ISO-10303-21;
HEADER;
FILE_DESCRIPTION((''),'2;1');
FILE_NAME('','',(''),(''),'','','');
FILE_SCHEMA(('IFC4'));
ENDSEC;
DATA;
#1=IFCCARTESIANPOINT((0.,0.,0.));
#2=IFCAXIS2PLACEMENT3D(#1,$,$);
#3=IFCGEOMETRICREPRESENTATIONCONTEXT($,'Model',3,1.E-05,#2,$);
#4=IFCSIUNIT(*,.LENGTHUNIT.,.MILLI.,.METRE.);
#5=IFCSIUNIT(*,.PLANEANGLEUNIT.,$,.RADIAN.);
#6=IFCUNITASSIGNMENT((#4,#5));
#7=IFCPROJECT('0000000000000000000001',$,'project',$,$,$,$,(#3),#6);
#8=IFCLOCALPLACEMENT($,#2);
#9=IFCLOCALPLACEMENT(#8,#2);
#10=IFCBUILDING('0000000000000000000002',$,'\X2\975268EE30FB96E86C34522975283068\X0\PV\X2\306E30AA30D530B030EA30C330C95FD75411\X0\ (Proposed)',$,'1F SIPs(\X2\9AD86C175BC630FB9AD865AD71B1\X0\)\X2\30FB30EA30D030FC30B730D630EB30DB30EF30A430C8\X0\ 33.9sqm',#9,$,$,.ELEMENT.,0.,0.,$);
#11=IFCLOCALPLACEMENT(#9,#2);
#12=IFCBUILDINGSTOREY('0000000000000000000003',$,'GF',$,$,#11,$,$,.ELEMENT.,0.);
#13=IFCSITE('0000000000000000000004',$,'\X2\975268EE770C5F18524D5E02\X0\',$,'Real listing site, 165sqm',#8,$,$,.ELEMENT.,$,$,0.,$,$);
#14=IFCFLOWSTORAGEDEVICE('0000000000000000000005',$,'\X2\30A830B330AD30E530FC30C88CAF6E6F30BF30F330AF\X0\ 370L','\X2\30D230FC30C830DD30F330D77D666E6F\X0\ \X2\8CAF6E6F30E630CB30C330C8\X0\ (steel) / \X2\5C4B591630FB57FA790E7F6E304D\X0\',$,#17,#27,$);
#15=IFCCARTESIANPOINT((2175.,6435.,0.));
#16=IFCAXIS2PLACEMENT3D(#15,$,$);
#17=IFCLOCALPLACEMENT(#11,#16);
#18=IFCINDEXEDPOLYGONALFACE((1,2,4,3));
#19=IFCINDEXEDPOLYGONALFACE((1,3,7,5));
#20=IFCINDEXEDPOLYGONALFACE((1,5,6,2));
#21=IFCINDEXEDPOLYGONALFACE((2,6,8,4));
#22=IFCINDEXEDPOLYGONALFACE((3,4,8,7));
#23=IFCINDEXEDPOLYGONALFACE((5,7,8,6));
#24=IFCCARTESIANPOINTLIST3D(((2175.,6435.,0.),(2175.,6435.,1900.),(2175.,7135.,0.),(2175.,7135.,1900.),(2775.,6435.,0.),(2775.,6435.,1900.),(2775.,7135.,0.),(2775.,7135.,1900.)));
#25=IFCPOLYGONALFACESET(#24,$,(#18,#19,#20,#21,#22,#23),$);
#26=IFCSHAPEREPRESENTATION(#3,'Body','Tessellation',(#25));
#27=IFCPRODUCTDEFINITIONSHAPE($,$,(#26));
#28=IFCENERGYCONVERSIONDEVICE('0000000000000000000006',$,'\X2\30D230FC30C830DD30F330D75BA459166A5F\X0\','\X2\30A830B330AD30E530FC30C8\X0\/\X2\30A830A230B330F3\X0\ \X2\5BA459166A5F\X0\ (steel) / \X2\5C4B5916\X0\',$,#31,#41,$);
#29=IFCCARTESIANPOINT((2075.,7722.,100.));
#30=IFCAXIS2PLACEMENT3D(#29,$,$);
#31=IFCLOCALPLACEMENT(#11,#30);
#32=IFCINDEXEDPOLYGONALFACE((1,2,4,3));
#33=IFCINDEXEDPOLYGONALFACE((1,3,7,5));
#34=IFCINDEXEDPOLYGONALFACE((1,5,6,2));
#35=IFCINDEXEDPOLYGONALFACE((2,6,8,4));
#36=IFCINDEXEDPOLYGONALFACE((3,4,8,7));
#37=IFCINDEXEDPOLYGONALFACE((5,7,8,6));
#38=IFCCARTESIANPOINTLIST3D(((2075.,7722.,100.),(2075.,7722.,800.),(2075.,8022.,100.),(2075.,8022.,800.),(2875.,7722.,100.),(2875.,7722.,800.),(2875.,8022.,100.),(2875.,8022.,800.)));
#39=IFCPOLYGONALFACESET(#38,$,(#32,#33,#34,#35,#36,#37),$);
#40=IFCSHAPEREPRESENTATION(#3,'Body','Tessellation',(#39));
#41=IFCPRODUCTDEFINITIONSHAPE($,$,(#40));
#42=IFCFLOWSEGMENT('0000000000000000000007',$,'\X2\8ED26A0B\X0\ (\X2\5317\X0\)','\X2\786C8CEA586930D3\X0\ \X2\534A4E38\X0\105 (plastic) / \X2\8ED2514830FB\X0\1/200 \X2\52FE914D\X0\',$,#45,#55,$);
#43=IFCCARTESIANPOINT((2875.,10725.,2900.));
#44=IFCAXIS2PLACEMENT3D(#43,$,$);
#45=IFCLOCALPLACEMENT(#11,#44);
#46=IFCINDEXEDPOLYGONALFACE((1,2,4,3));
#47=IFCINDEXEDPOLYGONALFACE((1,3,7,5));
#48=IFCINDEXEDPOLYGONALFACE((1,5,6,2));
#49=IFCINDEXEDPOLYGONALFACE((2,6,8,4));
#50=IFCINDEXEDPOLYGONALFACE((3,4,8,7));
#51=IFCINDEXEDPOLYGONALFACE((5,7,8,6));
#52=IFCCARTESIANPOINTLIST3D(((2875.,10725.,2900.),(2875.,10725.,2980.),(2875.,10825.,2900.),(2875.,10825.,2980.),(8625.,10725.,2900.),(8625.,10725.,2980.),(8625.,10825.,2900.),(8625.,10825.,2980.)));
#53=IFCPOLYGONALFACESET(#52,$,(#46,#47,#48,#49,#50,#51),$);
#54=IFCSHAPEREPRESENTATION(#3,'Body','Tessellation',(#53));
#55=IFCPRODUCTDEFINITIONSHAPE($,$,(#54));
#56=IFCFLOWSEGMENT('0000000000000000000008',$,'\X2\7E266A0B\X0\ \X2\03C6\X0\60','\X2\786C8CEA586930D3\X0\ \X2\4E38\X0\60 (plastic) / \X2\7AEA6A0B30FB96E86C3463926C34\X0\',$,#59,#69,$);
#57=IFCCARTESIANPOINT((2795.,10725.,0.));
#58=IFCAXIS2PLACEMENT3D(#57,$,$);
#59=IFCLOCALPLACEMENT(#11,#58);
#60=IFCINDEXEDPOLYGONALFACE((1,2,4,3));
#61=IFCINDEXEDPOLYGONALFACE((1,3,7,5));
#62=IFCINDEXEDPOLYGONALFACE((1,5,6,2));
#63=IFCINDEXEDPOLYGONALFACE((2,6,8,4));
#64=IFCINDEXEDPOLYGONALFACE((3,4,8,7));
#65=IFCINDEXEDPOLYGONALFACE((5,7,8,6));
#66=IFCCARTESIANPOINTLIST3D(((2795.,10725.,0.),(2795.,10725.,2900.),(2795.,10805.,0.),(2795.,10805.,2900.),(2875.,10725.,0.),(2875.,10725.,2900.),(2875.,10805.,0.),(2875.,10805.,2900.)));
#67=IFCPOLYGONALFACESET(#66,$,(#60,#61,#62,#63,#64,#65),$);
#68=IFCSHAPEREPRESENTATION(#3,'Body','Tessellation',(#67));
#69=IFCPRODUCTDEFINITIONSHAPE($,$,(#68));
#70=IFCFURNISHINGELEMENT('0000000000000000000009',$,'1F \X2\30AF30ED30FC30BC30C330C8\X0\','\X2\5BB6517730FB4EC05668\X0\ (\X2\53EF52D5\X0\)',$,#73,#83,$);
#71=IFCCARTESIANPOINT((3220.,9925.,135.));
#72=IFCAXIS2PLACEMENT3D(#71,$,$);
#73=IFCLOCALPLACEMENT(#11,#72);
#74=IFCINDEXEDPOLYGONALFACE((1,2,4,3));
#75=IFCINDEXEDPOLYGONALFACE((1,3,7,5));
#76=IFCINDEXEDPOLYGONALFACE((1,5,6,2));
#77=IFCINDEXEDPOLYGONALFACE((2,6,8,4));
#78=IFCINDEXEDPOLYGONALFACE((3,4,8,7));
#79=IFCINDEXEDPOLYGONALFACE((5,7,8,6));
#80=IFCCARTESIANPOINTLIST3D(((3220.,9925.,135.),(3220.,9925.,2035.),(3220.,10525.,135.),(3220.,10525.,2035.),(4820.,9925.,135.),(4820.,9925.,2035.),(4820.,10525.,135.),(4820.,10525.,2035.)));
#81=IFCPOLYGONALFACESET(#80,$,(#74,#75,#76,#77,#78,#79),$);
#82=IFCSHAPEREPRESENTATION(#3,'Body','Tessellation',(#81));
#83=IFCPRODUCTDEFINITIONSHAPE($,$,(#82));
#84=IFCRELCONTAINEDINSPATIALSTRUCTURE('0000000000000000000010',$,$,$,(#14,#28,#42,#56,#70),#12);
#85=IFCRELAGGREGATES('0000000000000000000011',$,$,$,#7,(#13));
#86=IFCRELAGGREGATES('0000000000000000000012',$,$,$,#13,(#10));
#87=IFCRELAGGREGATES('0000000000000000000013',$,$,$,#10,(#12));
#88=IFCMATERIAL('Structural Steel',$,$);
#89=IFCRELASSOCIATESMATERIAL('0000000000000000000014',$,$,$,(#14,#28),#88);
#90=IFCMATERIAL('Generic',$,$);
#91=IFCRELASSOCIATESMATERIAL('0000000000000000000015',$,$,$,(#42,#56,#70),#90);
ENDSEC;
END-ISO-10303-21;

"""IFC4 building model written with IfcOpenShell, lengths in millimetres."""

from ifc_helpers import new_model, si_unit, frame, frame_2d, origin, place, context, project, spatial, rectangle, extrude, material, element, save


model = new_model("IFC4")

# Units and contexts
model_context = context("Model", 3, precision=1e-05, world=origin())
ifc_project = project(units=[si_unit("LENGTHUNIT", "METRE", prefix="MILLI"), si_unit("PLANEANGLEUNIT", "RADIAN")], contexts=[model_context])

# Site, building, storey
site_placement = place(None, origin())
site = spatial("IfcSite", under=ifc_project, at=site_placement, Name="青森県弘前市", ObjectType="Real listing site, 165sqm", CompositionType="ELEMENT", RefElevation=0.0)
building_placement = place(site_placement, origin())
building = spatial("IfcBuilding", under=site, at=building_placement, Name="青森・雨水利用とPVのオフグリッド志向 (Proposed)", ObjectType="1F SIPs(高気密・高断熱)・リバーシブルホワイト 33.9sqm", CompositionType="ELEMENT", ElevationOfRefHeight=0.0, ElevationOfTerrain=0.0)
storey_placement = place(building_placement, origin())
storey = spatial("IfcBuildingStorey", under=building, at=storey_placement, Name="GF", CompositionType="ELEMENT", Elevation=0.0)

# Shared definitions
ifc_material_1 = material(Name="Structural Steel")

# Shared definitions
ifc_material_2 = material(Name="Generic")

# Flow storage device
flow_storage_device_placement = place(storey_placement, frame((2175.0, 6435.0, 0.0)))
element("IfcFlowStorageDevice", 1, at=flow_storage_device_placement, inside=storey, material=ifc_material_1, Name="エコキュート貯湯タンク 370L", Description="ヒートポンプ給湯 貯湯ユニット (steel) / 屋外・基礎置き", context=model_context, shape_type="SweptSolid", body=[
    extrude(rectangle(XDim=600.0, YDim=700.0, at=frame_2d((300.0, 350.0))), frame((2175.0, 6435.0, 0.0)), (0.0, 0.0, 1.0), 1900.0),
])

# Energy conversion device
energy_conversion_device_placement = place(storey_placement, frame((2075.0, 7722.0, 100.0)))
element("IfcEnergyConversionDevice", 2, at=energy_conversion_device_placement, inside=storey, material=ifc_material_1, Name="ヒートポンプ室外機", Description="エコキュート/エアコン 室外機 (steel) / 屋外", context=model_context, shape_type="SweptSolid", body=[
    extrude(rectangle(XDim=800.0, YDim=300.0, at=frame_2d((400.0, 150.0))), frame((2075.0, 7722.0, 100.0)), (0.0, 0.0, 1.0), 700.0),
])

# Flow segments
flow_segment_1_placement = place(storey_placement, frame((2875.0, 10725.0, 2900.0)))
element("IfcFlowSegment", 3, at=flow_segment_1_placement, inside=storey, material=ifc_material_2, Name="軒樋 (北)", Description="硬質塩ビ 半丸105 (plastic) / 軒先・1/200 勾配", context=model_context, shape_type="SweptSolid", body=[
    extrude(rectangle(XDim=5750.0, YDim=100.0, at=frame_2d((2875.0, 50.0))), frame((2875.0, 10725.0, 2900.0)), (0.0, 0.0, 1.0), 80.0),
])
flow_segment_2_placement = place(storey_placement, frame((2795.0, 10725.0, 0.0)))
element("IfcFlowSegment", 4, at=flow_segment_2_placement, inside=storey, material=ifc_material_2, Name="縦樋 φ60", Description="硬質塩ビ 丸60 (plastic) / 竪樋・雨水排水", context=model_context, shape_type="SweptSolid", body=[
    extrude(rectangle(XDim=80.0, YDim=80.0, at=frame_2d((40.0, 40.0))), frame((2795.0, 10725.0, 0.0)), (0.0, 0.0, 1.0), 2900.0),
])

# Furnishing element
furnishing_placement = place(storey_placement, frame((3220.0, 9925.0, 135.0)))
element("IfcFurnishingElement", 5, at=furnishing_placement, inside=storey, material=ifc_material_2, Name="1F クローゼット", Description="家具・什器 (可動)", context=model_context, shape_type="SweptSolid", body=[
    extrude(rectangle(XDim=1600.0, YDim=600.0, at=frame_2d((800.0, 300.0))), frame((3220.0, 9925.0, 135.0)), (0.0, 0.0, 1.0), 1900.0),
])

save(model, "model.ifc")
